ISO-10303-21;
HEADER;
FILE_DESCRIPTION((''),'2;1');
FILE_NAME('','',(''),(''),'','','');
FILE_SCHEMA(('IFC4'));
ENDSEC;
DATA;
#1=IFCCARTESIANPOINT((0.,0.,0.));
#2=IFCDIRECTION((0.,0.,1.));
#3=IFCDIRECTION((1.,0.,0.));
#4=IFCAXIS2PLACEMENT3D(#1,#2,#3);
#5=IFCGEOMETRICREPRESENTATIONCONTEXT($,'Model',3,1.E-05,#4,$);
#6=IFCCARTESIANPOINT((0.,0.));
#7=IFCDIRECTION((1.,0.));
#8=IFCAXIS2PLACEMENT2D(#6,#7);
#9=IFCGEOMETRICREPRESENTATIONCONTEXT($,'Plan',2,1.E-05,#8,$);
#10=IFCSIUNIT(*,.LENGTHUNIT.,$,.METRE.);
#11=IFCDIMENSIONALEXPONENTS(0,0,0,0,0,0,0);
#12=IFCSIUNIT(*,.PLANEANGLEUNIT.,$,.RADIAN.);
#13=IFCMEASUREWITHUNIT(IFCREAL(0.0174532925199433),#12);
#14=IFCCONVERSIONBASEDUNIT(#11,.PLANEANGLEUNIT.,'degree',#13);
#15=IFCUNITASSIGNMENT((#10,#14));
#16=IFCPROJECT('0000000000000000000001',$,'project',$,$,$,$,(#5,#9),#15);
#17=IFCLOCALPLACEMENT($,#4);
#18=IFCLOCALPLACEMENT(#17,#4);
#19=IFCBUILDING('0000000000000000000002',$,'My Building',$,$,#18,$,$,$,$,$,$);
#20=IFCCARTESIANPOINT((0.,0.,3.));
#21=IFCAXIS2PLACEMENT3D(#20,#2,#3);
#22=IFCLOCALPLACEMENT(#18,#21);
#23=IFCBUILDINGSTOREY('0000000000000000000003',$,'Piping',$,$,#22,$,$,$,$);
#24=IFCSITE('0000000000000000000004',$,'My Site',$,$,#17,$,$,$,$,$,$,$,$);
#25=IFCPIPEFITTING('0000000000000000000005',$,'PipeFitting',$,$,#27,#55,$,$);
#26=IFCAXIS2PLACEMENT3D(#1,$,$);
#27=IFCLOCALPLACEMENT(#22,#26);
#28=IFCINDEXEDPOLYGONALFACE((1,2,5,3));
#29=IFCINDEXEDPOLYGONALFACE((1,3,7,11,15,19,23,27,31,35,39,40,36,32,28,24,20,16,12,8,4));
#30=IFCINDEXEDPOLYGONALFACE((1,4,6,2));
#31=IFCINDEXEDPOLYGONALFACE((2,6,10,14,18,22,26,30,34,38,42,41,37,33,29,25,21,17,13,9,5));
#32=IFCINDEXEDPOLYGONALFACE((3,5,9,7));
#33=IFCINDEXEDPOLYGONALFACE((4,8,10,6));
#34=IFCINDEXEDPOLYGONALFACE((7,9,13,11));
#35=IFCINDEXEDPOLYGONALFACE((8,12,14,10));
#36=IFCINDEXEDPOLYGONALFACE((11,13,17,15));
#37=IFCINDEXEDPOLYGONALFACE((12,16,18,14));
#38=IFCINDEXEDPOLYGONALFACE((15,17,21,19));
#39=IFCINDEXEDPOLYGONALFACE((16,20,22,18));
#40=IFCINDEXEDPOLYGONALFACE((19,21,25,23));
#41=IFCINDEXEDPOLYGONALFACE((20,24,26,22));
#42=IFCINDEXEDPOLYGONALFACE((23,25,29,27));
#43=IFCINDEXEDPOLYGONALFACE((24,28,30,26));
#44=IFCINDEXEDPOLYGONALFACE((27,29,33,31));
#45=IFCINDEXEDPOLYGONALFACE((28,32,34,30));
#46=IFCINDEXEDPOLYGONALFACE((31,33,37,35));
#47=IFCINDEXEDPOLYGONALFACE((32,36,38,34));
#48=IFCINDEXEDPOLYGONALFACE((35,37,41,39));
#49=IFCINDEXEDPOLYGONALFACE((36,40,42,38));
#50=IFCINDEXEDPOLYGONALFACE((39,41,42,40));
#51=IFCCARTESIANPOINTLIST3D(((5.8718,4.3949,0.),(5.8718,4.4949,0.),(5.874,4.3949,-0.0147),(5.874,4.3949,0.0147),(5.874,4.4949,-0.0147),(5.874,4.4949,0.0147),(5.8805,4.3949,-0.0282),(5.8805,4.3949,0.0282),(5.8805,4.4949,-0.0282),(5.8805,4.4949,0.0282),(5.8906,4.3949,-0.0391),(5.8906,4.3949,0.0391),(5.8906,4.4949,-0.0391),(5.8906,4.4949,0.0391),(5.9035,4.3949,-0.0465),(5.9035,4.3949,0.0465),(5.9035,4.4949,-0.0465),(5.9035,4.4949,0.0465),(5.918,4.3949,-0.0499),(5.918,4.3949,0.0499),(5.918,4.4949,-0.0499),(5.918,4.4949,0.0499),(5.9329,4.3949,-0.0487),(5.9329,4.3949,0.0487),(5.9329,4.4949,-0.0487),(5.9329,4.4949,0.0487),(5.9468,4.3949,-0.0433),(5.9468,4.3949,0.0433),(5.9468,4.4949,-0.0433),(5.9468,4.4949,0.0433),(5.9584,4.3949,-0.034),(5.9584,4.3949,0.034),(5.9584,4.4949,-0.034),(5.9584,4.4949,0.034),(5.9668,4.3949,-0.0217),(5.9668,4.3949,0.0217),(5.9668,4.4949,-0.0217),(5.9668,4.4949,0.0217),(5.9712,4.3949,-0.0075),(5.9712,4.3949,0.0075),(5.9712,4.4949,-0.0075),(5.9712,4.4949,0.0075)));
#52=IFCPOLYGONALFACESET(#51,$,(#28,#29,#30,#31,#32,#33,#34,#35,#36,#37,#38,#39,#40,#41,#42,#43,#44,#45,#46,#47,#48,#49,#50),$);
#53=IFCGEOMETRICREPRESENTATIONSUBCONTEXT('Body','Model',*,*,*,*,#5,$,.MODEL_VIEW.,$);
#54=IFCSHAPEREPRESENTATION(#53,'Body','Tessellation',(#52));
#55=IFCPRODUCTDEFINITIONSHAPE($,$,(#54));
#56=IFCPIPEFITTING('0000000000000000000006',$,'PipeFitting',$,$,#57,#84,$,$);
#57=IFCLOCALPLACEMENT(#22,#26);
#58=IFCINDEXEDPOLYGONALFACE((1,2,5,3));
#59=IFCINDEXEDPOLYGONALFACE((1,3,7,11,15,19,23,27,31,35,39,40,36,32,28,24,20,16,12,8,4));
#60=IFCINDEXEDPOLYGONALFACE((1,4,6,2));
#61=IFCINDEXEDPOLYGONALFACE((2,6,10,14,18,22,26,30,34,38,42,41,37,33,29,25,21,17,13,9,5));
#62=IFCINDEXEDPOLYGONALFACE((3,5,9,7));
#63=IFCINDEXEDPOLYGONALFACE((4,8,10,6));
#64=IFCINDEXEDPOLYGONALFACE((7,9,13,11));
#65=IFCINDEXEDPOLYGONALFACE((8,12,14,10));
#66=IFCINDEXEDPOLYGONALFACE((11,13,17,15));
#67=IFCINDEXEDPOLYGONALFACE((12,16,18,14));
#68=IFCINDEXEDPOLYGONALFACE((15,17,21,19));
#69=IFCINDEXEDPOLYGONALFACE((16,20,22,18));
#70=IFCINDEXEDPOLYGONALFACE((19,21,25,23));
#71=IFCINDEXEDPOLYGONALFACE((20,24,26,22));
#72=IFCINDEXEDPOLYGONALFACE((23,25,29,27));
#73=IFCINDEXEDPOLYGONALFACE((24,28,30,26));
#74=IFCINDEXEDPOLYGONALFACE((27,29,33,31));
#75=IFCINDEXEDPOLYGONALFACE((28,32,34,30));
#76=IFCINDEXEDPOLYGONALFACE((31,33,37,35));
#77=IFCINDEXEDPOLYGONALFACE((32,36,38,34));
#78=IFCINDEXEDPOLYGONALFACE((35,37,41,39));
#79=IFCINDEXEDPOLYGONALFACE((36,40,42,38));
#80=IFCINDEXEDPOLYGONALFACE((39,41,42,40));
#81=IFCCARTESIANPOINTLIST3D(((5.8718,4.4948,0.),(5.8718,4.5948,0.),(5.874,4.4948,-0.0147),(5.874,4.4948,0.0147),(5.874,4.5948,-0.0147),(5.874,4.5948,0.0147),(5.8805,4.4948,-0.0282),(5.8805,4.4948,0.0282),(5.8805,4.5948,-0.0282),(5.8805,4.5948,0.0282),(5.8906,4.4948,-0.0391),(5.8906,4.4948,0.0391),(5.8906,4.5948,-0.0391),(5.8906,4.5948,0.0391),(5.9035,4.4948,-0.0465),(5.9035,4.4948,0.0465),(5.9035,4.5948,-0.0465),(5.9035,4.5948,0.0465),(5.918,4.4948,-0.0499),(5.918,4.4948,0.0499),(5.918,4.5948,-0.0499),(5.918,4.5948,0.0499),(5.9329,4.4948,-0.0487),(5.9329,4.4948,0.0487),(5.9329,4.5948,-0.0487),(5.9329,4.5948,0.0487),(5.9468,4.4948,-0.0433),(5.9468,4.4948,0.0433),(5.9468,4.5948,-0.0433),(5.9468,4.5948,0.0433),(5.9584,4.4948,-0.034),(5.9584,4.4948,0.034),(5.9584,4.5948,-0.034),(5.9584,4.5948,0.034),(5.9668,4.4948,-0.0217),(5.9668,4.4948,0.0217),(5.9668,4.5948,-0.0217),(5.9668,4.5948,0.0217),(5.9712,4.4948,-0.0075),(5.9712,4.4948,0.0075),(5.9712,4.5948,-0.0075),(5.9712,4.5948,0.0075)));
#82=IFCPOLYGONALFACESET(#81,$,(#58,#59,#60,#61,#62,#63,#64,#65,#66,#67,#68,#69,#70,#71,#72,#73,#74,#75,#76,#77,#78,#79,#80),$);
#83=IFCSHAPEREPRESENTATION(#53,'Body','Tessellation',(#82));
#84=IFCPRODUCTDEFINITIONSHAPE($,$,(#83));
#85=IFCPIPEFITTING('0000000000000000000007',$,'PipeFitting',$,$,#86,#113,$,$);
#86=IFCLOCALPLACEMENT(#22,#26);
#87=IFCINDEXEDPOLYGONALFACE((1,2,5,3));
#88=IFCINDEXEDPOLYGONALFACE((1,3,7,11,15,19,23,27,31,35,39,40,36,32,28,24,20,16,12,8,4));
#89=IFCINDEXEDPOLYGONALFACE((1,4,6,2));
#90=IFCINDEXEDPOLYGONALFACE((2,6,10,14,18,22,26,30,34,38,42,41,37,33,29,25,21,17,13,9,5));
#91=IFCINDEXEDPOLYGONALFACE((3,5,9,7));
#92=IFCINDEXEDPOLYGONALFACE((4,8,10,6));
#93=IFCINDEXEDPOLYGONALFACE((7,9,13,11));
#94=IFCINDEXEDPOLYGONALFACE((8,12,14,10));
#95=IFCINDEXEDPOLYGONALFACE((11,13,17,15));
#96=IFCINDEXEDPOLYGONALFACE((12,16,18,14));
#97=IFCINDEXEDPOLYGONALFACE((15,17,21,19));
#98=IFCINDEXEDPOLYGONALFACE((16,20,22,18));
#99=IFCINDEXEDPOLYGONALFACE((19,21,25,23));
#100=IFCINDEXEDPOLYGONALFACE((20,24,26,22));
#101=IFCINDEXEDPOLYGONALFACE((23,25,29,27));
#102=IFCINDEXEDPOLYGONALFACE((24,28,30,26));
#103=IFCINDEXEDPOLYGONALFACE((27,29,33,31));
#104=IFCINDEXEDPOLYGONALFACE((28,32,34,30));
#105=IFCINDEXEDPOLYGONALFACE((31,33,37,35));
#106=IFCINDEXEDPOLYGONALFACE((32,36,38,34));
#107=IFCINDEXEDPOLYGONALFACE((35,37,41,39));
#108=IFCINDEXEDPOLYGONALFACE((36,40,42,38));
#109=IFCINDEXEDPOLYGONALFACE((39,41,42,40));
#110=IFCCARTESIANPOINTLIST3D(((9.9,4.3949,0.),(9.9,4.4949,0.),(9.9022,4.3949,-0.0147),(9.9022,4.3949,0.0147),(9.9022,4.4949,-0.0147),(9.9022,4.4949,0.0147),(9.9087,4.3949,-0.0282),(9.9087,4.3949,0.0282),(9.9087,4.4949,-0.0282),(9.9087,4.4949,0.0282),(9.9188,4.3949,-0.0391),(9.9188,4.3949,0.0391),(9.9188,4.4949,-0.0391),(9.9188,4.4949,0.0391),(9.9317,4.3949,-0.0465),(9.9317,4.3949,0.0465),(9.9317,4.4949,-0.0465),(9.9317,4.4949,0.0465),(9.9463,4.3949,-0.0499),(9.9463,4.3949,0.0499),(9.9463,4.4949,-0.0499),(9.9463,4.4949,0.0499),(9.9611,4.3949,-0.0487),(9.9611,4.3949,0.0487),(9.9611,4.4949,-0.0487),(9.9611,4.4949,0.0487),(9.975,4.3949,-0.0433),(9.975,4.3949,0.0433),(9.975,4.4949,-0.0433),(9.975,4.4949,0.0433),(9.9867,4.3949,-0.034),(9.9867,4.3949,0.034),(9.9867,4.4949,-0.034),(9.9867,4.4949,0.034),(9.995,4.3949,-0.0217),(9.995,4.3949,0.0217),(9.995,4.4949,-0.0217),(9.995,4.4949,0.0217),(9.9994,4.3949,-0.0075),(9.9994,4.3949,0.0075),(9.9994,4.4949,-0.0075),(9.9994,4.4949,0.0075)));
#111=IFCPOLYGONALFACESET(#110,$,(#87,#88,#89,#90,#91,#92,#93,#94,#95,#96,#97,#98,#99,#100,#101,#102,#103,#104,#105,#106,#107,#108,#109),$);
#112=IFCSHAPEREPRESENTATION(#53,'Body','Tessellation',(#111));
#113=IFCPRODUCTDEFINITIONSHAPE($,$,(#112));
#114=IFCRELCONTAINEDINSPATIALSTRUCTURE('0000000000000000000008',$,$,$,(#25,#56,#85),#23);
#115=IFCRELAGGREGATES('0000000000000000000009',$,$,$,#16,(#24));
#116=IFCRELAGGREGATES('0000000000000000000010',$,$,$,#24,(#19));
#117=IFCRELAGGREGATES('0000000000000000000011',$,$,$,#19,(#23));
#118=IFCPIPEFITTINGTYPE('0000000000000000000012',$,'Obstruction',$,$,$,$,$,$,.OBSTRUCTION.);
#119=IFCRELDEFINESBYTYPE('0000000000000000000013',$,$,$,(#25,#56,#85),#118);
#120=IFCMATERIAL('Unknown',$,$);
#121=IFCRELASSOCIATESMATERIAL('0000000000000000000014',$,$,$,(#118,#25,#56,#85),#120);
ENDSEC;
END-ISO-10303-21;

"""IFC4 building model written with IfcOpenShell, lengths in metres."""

from ifc_helpers import new_model, entity, si_unit, converted_unit, frame, origin_with_axes, origin_2d_with_axis, place, context, subcontext, project, spatial, circle, extrude, material, material_profile, profile_set, profile_usage, type_object, element, save


model = new_model("IFC4")

# Units and contexts
model_context = context("Model", 3, precision=1e-05, world=origin_with_axes())
plan_context = context("Plan", 2, precision=1e-05, world=origin_2d_with_axis())
body_context = subcontext(model_context, "Body", "Model", "MODEL_VIEW")
ifc_project = project(units=[si_unit("LENGTHUNIT", "METRE"), converted_unit("PLANEANGLEUNIT", "degree", entity("IfcReal", 0.0174532925199433), si_unit("PLANEANGLEUNIT", "RADIAN"), dimensions=[0, 0, 0, 0, 0, 0, 0])], contexts=[model_context, plan_context])

# Site, building, storey
site_placement = place(None, origin_with_axes())
site = spatial("IfcSite", under=ifc_project, at=site_placement, Name="My Site")
building_placement = place(site_placement, origin_with_axes())
building = spatial("IfcBuilding", under=site, at=building_placement, Name="My Building")
storey_placement = place(building_placement, frame((0.0, 0.0, 3.0), z_axis=(0.0, 0.0, 1.0), x_axis=(1.0, 0.0, 0.0)))
storey = spatial("IfcBuildingStorey", under=building, at=storey_placement, Name="Piping")

# Shared definitions
ifc_material = material(Name="Unknown")

# Pipe fittings
ifc_material_profile_1 = material_profile(ifc_material, circle(Radius=0.05))
ifc_profile_set_1 = profile_set([ifc_material_profile_1])
pipe_fitting_type_1 = type_object("IfcPipeFittingType", Name="Obstruction", PredefinedType="OBSTRUCTION", material=ifc_profile_set_1)
ifc_profile_usage_1 = profile_usage(ifc_profile_set_1, cardinal=5)
pipe_fitting_1_placement = place(storey_placement, frame((5.9218, 4.3949, 0.0), z_axis=(0.0, 1.0, 0.0), x_axis=(-1.0, 0.0, 0.0)))
element("IfcPipeFitting", 1, at=pipe_fitting_1_placement, inside=storey, type_object=pipe_fitting_type_1, material=ifc_profile_usage_1, Name="PipeFitting", context=body_context, shape_type="SweptSolid", body=[
    extrude(circle(Radius=0.05), origin_with_axes(), (0.0, 0.0, 1.0), 0.1),
])
ifc_profile_usage_2 = profile_usage(ifc_profile_set_1, cardinal=5)
pipe_fitting_2_placement = place(storey_placement, frame((5.9218, 4.4948, 0.0), z_axis=(0.0, 1.0, 0.0), x_axis=(-1.0, 0.0, 0.0)))
element("IfcPipeFitting", 2, at=pipe_fitting_2_placement, inside=storey, type_object=pipe_fitting_type_1, material=ifc_profile_usage_2, Name="PipeFitting", context=body_context, shape_type="SweptSolid", body=[
    extrude(circle(Radius=0.05), origin_with_axes(), (0.0, 0.0, 1.0), 0.1),
])
ifc_profile_usage_3 = profile_usage(ifc_profile_set_1, cardinal=5)
pipe_fitting_3_placement = place(storey_placement, frame((9.95, 4.3949, 0.0), z_axis=(0.0, 1.0, 0.0), x_axis=(-1.0, 0.0, 0.0)))
element("IfcPipeFitting", 3, at=pipe_fitting_3_placement, inside=storey, type_object=pipe_fitting_type_1, material=ifc_profile_usage_3, Name="PipeFitting", context=body_context, shape_type="SweptSolid", body=[
    extrude(circle(Radius=0.05), origin_with_axes(), (0.0, 0.0, 1.0), 0.1),
])

save(model, "model.ifc")
